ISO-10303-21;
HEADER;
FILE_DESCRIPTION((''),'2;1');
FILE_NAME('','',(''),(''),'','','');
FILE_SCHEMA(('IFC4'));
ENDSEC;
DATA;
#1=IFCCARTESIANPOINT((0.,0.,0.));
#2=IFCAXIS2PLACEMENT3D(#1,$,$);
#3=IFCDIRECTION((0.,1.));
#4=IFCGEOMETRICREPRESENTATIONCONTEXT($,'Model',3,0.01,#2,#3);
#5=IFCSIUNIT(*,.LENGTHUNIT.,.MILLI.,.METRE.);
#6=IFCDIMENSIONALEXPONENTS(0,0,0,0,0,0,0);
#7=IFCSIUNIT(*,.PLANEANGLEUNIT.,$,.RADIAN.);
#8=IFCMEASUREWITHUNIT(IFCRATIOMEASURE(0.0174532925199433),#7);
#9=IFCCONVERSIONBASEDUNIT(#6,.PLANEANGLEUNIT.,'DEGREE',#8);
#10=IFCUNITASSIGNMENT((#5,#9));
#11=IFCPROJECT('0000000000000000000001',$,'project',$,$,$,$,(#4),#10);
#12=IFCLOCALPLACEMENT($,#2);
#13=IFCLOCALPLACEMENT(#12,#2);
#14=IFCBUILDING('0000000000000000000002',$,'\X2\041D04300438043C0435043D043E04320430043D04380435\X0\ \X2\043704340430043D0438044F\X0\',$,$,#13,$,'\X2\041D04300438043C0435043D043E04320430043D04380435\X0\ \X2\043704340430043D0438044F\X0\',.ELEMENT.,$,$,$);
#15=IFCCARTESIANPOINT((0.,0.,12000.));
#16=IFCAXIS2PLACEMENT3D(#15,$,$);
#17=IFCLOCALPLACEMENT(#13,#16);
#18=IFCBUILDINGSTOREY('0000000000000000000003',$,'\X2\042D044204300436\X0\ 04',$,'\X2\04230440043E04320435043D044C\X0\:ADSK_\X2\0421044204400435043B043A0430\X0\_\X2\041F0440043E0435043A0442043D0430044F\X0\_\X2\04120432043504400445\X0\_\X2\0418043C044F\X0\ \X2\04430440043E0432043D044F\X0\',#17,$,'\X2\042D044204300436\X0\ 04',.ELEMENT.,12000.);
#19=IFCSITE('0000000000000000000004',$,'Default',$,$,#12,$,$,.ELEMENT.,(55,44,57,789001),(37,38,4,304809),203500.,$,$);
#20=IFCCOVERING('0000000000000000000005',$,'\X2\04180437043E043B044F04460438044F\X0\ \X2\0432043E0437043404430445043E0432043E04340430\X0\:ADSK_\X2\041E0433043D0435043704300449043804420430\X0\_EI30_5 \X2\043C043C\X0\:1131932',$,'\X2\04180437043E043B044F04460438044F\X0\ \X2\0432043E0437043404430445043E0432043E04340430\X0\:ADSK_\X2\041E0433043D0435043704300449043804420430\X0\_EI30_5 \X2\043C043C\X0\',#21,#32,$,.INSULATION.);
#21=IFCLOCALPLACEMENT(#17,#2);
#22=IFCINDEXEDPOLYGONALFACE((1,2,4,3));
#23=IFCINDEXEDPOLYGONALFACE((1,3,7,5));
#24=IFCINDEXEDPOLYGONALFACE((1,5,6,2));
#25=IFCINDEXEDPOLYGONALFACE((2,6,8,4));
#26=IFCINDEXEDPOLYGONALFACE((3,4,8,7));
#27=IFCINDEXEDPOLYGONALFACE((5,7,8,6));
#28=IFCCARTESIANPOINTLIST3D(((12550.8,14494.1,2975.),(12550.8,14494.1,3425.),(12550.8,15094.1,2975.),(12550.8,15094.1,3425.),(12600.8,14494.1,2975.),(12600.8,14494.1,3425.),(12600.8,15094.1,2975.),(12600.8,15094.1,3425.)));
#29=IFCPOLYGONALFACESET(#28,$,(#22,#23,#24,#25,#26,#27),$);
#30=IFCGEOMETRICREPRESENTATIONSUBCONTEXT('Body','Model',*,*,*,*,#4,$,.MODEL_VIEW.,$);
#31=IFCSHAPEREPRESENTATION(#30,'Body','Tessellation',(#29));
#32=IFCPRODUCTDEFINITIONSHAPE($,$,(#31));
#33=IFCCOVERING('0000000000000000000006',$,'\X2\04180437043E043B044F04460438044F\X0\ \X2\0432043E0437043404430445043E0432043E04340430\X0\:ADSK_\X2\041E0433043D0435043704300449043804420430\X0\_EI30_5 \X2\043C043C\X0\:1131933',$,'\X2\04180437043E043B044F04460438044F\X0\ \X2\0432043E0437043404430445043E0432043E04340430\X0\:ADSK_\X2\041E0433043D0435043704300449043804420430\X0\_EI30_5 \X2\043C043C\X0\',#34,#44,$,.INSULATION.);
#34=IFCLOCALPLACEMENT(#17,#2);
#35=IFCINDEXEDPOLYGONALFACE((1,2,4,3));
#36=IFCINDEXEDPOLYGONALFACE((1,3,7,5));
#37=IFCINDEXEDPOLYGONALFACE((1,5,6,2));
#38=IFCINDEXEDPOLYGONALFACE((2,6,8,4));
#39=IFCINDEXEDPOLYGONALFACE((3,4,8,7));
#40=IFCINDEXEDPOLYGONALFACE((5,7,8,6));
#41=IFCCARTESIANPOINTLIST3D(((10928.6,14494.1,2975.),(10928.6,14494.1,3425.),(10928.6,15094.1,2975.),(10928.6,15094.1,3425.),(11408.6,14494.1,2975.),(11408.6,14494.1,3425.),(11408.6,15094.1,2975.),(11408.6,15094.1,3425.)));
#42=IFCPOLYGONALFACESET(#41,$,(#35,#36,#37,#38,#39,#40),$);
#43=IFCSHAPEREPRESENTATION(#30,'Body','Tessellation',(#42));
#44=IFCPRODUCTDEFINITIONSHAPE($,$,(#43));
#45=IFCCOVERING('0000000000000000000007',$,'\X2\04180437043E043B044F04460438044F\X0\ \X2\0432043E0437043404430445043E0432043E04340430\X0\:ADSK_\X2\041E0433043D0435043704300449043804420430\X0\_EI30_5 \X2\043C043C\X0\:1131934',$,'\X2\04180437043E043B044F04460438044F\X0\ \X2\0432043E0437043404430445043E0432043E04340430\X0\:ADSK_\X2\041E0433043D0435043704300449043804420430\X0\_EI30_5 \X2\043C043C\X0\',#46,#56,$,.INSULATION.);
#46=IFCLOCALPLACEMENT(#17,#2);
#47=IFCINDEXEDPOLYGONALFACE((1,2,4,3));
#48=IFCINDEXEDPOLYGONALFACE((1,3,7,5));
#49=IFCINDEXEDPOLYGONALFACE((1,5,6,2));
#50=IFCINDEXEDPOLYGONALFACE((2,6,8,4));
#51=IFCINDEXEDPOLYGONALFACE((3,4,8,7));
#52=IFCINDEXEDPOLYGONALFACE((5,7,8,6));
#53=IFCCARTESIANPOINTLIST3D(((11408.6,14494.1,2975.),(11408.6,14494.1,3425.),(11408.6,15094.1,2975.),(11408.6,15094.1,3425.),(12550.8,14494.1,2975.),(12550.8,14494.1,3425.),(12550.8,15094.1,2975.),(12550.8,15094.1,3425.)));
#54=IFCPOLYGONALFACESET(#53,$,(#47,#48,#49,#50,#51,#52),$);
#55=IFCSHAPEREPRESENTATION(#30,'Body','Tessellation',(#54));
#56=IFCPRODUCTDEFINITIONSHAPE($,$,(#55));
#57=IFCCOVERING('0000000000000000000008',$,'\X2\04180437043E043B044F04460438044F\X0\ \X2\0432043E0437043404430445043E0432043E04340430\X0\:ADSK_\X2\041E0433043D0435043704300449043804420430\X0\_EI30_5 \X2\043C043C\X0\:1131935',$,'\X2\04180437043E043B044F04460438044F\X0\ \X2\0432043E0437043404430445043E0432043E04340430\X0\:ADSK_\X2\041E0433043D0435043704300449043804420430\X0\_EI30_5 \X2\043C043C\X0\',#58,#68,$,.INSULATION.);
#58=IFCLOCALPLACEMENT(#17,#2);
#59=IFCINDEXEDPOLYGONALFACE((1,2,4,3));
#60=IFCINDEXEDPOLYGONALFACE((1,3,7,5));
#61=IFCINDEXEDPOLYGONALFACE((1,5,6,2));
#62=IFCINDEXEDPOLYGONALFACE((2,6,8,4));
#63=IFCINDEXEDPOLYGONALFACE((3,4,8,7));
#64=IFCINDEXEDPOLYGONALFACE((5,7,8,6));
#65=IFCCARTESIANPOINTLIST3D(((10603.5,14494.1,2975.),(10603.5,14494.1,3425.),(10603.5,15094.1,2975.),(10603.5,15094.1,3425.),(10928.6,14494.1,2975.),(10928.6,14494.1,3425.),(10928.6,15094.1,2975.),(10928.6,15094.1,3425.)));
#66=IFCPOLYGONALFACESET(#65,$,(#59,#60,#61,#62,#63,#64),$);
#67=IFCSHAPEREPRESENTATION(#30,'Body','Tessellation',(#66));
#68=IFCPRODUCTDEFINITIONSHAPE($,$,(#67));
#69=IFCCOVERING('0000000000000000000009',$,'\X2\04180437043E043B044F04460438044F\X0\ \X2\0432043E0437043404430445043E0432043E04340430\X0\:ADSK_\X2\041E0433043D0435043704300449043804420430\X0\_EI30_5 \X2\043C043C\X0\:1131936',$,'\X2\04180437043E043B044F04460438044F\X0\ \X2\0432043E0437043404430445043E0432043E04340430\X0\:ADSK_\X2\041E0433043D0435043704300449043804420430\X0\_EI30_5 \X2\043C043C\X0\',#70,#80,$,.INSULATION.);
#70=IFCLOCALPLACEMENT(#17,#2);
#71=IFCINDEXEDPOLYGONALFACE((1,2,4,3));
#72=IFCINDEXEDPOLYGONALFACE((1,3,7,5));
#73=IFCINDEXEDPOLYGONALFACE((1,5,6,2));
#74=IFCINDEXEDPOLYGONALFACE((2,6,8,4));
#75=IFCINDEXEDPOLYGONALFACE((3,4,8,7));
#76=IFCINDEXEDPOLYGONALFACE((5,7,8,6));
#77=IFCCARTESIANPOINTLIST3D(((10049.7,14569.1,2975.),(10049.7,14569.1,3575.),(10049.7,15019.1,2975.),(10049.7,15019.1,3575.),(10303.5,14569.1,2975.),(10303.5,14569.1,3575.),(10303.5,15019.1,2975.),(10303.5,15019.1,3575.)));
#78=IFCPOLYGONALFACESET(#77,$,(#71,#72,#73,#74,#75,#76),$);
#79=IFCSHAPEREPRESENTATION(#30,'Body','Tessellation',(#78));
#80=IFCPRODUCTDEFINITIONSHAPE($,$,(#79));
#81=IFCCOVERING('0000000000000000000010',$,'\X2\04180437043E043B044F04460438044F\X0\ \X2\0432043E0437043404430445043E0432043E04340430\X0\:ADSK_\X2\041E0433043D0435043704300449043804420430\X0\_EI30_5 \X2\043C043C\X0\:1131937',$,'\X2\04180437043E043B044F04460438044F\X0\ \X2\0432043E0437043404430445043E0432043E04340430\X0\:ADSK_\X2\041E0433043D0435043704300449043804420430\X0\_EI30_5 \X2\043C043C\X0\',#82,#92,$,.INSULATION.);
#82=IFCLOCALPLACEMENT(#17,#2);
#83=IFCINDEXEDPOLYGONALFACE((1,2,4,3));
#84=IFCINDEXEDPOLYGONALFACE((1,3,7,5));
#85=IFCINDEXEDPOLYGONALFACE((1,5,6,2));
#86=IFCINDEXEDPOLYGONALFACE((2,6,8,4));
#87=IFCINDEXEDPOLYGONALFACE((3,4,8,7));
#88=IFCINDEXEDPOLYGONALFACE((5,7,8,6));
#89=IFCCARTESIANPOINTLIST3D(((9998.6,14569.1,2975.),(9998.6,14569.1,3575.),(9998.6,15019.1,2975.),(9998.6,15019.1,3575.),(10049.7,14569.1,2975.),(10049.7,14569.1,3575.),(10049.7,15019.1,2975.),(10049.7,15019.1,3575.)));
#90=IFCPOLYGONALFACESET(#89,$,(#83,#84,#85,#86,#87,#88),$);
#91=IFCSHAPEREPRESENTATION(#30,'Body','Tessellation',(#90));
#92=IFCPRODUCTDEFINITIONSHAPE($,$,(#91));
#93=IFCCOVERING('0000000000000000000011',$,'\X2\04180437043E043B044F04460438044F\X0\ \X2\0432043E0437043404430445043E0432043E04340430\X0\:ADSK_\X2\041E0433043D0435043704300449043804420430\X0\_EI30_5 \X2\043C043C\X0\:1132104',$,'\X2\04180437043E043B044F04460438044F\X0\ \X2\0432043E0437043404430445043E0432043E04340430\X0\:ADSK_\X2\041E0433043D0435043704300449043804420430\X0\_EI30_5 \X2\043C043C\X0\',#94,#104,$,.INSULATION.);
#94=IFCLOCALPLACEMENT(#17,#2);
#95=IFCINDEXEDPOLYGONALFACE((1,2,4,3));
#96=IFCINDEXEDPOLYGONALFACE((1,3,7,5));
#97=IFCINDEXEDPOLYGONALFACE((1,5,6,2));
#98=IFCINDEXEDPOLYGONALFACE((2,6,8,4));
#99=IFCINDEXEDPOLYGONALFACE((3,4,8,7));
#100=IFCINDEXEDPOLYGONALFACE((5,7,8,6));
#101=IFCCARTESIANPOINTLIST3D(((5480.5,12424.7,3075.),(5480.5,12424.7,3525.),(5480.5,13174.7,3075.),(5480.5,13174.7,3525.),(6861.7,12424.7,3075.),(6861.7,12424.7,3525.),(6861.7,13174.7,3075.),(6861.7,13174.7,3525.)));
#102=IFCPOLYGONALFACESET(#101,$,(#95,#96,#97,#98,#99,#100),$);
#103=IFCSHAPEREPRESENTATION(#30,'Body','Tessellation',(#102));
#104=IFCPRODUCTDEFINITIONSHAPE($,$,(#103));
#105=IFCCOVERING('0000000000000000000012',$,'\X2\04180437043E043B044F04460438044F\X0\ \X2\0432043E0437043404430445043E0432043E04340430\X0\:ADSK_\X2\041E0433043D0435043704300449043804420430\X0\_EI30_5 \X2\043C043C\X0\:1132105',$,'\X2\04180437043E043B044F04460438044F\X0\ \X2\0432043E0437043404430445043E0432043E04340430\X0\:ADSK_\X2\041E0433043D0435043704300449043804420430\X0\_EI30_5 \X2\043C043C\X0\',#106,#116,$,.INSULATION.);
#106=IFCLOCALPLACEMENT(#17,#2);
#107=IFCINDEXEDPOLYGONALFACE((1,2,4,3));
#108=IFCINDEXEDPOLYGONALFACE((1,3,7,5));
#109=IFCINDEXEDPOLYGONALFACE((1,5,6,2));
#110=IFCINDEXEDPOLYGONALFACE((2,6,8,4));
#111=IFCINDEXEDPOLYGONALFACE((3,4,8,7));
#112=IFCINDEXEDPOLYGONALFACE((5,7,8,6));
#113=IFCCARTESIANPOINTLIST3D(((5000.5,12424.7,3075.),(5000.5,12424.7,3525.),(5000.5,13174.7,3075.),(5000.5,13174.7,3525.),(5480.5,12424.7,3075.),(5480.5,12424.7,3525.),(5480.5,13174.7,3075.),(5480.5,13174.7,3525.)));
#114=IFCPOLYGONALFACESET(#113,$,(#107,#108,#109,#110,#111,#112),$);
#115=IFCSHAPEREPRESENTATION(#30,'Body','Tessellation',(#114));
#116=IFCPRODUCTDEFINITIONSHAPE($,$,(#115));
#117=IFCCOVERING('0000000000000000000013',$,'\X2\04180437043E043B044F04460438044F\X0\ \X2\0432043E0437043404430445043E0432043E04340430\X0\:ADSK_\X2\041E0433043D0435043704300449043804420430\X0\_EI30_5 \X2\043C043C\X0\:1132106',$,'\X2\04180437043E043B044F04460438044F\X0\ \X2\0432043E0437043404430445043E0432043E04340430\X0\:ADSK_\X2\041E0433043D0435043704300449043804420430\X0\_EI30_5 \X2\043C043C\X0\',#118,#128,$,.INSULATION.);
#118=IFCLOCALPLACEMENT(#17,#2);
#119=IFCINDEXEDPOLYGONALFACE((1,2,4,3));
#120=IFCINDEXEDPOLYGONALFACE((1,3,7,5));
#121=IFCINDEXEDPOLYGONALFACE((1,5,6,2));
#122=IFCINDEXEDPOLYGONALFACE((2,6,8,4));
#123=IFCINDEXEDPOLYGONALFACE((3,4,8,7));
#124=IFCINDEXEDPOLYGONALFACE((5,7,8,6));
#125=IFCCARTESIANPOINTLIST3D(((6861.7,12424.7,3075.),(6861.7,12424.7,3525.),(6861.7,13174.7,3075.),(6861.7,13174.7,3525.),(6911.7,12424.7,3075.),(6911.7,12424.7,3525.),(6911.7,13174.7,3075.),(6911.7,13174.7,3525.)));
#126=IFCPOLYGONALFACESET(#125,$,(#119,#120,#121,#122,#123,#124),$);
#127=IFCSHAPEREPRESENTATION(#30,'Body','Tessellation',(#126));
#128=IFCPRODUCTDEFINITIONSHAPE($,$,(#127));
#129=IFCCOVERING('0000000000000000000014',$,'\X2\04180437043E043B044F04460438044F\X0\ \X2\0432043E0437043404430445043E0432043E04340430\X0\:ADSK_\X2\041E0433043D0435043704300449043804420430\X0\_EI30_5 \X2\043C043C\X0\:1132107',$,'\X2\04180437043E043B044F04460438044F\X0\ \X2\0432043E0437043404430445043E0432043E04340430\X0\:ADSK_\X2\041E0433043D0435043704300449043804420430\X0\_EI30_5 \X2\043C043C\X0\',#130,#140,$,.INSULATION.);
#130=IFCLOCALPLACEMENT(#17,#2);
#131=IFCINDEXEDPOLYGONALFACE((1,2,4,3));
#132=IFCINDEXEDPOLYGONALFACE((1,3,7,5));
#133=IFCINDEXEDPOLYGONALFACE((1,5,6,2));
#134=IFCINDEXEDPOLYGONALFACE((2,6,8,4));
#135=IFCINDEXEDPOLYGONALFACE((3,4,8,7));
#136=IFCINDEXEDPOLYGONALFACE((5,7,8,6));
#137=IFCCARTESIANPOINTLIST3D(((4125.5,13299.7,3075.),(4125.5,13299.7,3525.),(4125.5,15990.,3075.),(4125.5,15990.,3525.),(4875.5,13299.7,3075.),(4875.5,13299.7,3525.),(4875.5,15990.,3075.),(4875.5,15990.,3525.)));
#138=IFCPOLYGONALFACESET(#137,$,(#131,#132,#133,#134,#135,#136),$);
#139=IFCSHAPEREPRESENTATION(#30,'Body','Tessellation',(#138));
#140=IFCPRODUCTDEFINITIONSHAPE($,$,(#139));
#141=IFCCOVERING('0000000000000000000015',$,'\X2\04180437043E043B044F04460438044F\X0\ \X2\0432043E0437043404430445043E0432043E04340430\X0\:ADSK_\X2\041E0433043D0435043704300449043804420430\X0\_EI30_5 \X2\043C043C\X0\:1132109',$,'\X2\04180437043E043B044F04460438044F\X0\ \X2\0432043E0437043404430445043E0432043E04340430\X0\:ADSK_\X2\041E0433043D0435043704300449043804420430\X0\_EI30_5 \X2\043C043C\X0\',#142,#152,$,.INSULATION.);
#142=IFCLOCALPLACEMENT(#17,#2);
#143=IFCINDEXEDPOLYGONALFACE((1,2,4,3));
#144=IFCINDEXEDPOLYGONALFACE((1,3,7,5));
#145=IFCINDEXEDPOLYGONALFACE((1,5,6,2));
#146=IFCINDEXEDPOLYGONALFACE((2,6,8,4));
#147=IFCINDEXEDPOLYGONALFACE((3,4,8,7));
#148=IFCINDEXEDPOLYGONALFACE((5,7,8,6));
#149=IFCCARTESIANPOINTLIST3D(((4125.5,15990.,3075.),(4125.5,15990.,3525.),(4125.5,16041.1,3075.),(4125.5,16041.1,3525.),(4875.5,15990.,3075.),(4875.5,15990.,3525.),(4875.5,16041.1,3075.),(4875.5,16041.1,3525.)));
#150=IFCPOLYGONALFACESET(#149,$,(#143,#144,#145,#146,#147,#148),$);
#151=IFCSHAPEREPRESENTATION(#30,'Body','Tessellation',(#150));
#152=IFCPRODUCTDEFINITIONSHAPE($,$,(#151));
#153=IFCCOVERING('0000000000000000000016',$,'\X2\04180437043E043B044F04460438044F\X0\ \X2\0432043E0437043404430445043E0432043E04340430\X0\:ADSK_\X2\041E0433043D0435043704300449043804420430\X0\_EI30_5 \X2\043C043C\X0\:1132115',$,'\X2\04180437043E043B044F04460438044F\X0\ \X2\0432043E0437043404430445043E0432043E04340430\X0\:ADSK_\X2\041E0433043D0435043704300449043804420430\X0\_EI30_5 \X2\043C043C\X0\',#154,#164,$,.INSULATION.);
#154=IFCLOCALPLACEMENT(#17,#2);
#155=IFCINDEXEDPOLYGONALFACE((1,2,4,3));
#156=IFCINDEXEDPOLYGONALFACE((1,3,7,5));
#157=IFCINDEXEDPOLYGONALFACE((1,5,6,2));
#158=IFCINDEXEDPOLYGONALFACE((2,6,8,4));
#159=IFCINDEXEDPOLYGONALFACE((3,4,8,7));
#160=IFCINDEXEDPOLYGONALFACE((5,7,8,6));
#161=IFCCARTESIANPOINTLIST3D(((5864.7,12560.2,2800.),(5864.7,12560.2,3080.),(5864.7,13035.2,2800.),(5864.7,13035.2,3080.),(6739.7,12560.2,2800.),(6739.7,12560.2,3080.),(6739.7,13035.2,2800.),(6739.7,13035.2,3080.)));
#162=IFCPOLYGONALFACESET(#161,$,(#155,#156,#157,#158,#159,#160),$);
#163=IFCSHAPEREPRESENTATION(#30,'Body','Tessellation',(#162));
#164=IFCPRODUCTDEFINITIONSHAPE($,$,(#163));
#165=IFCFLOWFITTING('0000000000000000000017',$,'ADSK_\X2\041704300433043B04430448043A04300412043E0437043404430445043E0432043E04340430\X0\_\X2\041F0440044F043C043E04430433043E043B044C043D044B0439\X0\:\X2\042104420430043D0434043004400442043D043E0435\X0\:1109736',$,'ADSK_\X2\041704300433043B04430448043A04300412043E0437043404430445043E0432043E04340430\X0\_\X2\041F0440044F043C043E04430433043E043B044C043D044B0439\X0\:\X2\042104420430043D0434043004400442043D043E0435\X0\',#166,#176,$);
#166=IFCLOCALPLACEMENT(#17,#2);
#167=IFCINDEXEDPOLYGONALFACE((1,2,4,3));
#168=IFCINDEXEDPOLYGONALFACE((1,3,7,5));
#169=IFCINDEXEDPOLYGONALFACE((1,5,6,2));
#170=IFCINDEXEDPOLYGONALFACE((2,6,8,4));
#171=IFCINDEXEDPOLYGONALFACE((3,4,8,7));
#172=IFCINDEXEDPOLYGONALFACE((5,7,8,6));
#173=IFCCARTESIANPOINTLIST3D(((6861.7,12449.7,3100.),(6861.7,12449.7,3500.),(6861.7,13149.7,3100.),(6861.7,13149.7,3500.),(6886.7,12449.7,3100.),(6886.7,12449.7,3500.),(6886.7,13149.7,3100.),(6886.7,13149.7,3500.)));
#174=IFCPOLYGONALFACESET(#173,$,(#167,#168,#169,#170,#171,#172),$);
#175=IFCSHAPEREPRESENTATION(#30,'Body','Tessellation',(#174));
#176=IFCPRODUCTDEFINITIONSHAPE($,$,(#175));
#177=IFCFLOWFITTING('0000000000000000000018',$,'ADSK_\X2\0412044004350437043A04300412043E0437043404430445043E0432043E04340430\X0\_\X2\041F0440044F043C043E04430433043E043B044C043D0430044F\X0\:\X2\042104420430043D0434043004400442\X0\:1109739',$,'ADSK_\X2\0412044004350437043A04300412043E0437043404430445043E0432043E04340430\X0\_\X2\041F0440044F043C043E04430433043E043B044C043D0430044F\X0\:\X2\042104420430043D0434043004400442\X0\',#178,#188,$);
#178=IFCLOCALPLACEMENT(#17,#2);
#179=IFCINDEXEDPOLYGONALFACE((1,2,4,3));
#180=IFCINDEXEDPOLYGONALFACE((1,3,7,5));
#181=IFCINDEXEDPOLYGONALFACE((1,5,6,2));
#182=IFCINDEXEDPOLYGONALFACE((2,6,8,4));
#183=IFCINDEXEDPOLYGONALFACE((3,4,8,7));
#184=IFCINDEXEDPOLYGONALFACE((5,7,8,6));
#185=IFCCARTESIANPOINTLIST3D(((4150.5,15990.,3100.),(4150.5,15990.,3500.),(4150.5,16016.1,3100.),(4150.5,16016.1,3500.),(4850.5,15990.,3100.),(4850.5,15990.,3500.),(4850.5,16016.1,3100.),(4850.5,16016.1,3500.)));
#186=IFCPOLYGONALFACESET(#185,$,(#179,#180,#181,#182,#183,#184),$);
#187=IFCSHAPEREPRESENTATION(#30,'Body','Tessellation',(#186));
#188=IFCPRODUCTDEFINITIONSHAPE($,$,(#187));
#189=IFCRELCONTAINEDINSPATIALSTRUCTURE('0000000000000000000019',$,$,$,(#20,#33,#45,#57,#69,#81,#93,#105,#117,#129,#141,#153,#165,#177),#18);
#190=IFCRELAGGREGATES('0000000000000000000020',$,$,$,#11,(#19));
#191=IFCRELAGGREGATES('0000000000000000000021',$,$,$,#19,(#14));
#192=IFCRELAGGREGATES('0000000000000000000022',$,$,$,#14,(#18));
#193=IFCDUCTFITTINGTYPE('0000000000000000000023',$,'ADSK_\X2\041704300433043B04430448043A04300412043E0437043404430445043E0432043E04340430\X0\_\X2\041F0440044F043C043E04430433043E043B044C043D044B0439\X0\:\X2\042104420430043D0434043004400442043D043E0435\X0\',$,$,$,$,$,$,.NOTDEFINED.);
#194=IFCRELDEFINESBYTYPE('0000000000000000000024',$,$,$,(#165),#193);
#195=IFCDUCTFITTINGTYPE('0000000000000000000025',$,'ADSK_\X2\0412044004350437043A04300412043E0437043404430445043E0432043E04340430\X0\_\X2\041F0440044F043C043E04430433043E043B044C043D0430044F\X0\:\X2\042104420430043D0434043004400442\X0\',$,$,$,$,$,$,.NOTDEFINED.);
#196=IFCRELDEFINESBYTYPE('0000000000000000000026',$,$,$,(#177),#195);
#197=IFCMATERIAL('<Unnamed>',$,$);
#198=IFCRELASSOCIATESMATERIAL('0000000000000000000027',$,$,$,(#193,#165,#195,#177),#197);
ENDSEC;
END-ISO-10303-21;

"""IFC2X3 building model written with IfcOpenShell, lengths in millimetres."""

from ifc_helpers import new_model, entity, si_unit, converted_unit, direction, frame, frame_2d, origin, origin_2d_with_axis, place, context, subcontext, project, spatial, rectangle, extrude, source, transform, mapped, material, type_object, type_shapes, element, save


model = new_model("IFC2X3")

# Units and contexts
model_context = context("Model", 3, precision=0.01, world=origin(), true_north=direction((0.0, 1.0)))
body_context = subcontext(model_context, "Body", "Model", "MODEL_VIEW")
ifc_project = project(units=[si_unit("LENGTHUNIT", "METRE", prefix="MILLI"), converted_unit("PLANEANGLEUNIT", "DEGREE", entity("IfcRatioMeasure", 0.0174532925199433), si_unit("PLANEANGLEUNIT", "RADIAN"), dimensions=[0, 0, 0, 0, 0, 0, 0])], contexts=[model_context])

# Site, building, storey
site_placement = place(None, frame((0.0, 0.0, 0.0)))
site = spatial("IfcSite", under=ifc_project, at=site_placement, Name="Default", CompositionType="ELEMENT", RefLatitude=(55, 44, 57, 789001), RefLongitude=(37, 38, 4, 304809), RefElevation=203500.0)
building_placement = place(site_placement, origin())
building = spatial("IfcBuilding", under=site, at=building_placement, Name="Наименование здания", LongName="Наименование здания", CompositionType="ELEMENT")
storey_placement = place(building_placement, frame((0.0, 0.0, 12000.0)))
storey = spatial("IfcBuildingStorey", under=building, at=storey_placement, Name="Этаж 04", ObjectType="Уровень:ADSK_Стрелка_Проектная_Вверх_Имя уровня", LongName="Этаж 04", CompositionType="ELEMENT", Elevation=12000.0)

# Coverings
covering_1_placement = place(storey_placement, frame((12550.8, 14494.1, 2975.0)))
element("IfcCovering", 1, at=covering_1_placement, inside=storey, Name="Изоляция воздуховода:ADSK_Огнезащита_EI30_5 мм:1131932", ObjectType="Изоляция воздуховода:ADSK_Огнезащита_EI30_5 мм", PredefinedType="INSULATION", context=body_context, shape_type="SweptSolid", body=[
    extrude(rectangle(XDim=50.0, YDim=600.0, at=frame_2d((0.0, 0.0), x_axis=(1.0, 0.0))), frame((25.0, 300.0, 0.0), z_axis=(0.0, 0.0, 1.0), x_axis=(-1.0, 0.0, 0.0)), (0.0, 0.0, 1.0), 450.0),
])
covering_2_placement = place(storey_placement, frame((10928.6, 14494.1, 2975.0)))
element("IfcCovering", 2, at=covering_2_placement, inside=storey, Name="Изоляция воздуховода:ADSK_Огнезащита_EI30_5 мм:1131933", ObjectType="Изоляция воздуховода:ADSK_Огнезащита_EI30_5 мм", PredefinedType="INSULATION", context=body_context, shape_type="SweptSolid", body=[
    extrude(rectangle(XDim=480.0, YDim=600.0, at=frame_2d((0.0, 0.0), x_axis=(1.0, 0.0))), frame((240.0, 300.0, 0.0), z_axis=(0.0, 0.0, 1.0), x_axis=(-1.0, 0.0, 0.0)), (0.0, 0.0, 1.0), 450.0),
])
covering_3_placement = place(storey_placement, frame((11408.6, 14494.1, 2975.0)))
element("IfcCovering", 3, at=covering_3_placement, inside=storey, Name="Изоляция воздуховода:ADSK_Огнезащита_EI30_5 мм:1131934", ObjectType="Изоляция воздуховода:ADSK_Огнезащита_EI30_5 мм", PredefinedType="INSULATION", context=body_context, shape_type="SweptSolid", body=[
    extrude(rectangle(XDim=1142.1, YDim=600.0, at=origin_2d_with_axis()), frame((571.1, 300.0, 0.0), z_axis=(0.0, 0.0, 1.0), x_axis=(-1.0, 0.0, 0.0)), (0.0, 0.0, 1.0), 450.0),
])
covering_4_placement = place(storey_placement, frame((10603.5, 14494.1, 2975.0)))
element("IfcCovering", 4, at=covering_4_placement, inside=storey, Name="Изоляция воздуховода:ADSK_Огнезащита_EI30_5 мм:1131935", ObjectType="Изоляция воздуховода:ADSK_Огнезащита_EI30_5 мм", PredefinedType="INSULATION", context=body_context, shape_type="SweptSolid", body=[
    extrude(rectangle(XDim=325.1, YDim=600.0, at=origin_2d_with_axis()), frame((162.6, 300.0, 0.0), z_axis=(0.0, 0.0, 1.0), x_axis=(-1.0, 0.0, 0.0)), (0.0, 0.0, 1.0), 450.0),
])
covering_5_placement = place(storey_placement, frame((10049.7, 14569.1, 2975.0)))
element("IfcCovering", 5, at=covering_5_placement, inside=storey, Name="Изоляция воздуховода:ADSK_Огнезащита_EI30_5 мм:1131936", ObjectType="Изоляция воздуховода:ADSK_Огнезащита_EI30_5 мм", PredefinedType="INSULATION", context=body_context, shape_type="SweptSolid", body=[
    extrude(rectangle(XDim=253.8, YDim=450.0, at=frame_2d((0.0, 0.0), x_axis=(1.0, 0.0))), frame((126.9, 225.0, 0.0), z_axis=(0.0, 0.0, 1.0), x_axis=(-1.0, 0.0, 0.0)), (0.0, 0.0, 1.0), 600.0),
])
covering_6_placement = place(storey_placement, frame((9998.6, 14569.1, 2975.0)))
element("IfcCovering", 6, at=covering_6_placement, inside=storey, Name="Изоляция воздуховода:ADSK_Огнезащита_EI30_5 мм:1131937", ObjectType="Изоляция воздуховода:ADSK_Огнезащита_EI30_5 мм", PredefinedType="INSULATION", context=body_context, shape_type="SweptSolid", body=[
    extrude(rectangle(XDim=450.0, YDim=51.1, at=frame_2d((0.0, 0.0), x_axis=(1.0, 0.0))), frame((25.5, 225.0, 0.0), z_axis=(0.0, 0.0, 1.0), x_axis=(0.0, 1.0, 0.0)), (0.0, 0.0, 1.0), 600.0),
])
covering_7_placement = place(storey_placement, frame((5480.5, 12424.7, 3075.0)))
element("IfcCovering", 7, at=covering_7_placement, inside=storey, Name="Изоляция воздуховода:ADSK_Огнезащита_EI30_5 мм:1132104", ObjectType="Изоляция воздуховода:ADSK_Огнезащита_EI30_5 мм", PredefinedType="INSULATION", context=body_context, shape_type="SweptSolid", body=[
    extrude(rectangle(XDim=1381.3, YDim=750.0, at=origin_2d_with_axis()), frame((690.6, 375.0, 0.0)), (0.0, 0.0, 1.0), 450.0),
])
covering_8_placement = place(storey_placement, frame((5000.5, 12424.7, 3075.0)))
element("IfcCovering", 8, at=covering_8_placement, inside=storey, Name="Изоляция воздуховода:ADSK_Огнезащита_EI30_5 мм:1132105", ObjectType="Изоляция воздуховода:ADSK_Огнезащита_EI30_5 мм", PredefinedType="INSULATION", context=body_context, shape_type="SweptSolid", body=[
    extrude(rectangle(XDim=480.0, YDim=750.0, at=frame_2d((0.0, 0.0), x_axis=(1.0, 0.0))), frame((240.0, 375.0, 0.0)), (0.0, 0.0, 1.0), 450.0),
])
covering_9_placement = place(storey_placement, frame((6861.7, 12424.7, 3075.0)))
element("IfcCovering", 9, at=covering_9_placement, inside=storey, Name="Изоляция воздуховода:ADSK_Огнезащита_EI30_5 мм:1132106", ObjectType="Изоляция воздуховода:ADSK_Огнезащита_EI30_5 мм", PredefinedType="INSULATION", context=body_context, shape_type="SweptSolid", body=[
    extrude(rectangle(XDim=50.0, YDim=750.0, at=frame_2d((0.0, 0.0), x_axis=(1.0, 0.0))), frame((25.0, 375.0, 0.0), z_axis=(0.0, 0.0, 1.0), x_axis=(-1.0, 0.0, 0.0)), (0.0, 0.0, 1.0), 450.0),
])
covering_10_placement = place(storey_placement, frame((4125.5, 13299.7, 3075.0)))
element("IfcCovering", 10, at=covering_10_placement, inside=storey, Name="Изоляция воздуховода:ADSK_Огнезащита_EI30_5 мм:1132107", ObjectType="Изоляция воздуховода:ADSK_Огнезащита_EI30_5 мм", PredefinedType="INSULATION", context=body_context, shape_type="SweptSolid", body=[
    extrude(rectangle(XDim=2690.3, YDim=750.0, at=frame_2d((0.0, 0.0), x_axis=(1.0, 0.0))), frame((375.0, 1345.2, 0.0), z_axis=(0.0, 0.0, 1.0), x_axis=(0.0, 1.0, 0.0)), (0.0, 0.0, 1.0), 450.0),
])
covering_11_placement = place(storey_placement, frame((4125.5, 15990.0, 3075.0)))
element("IfcCovering", 11, at=covering_11_placement, inside=storey, Name="Изоляция воздуховода:ADSK_Огнезащита_EI30_5 мм:1132109", ObjectType="Изоляция воздуховода:ADSK_Огнезащита_EI30_5 мм", PredefinedType="INSULATION", context=body_context, shape_type="SweptSolid", body=[
    extrude(rectangle(XDim=750.0, YDim=51.1, at=frame_2d((0.0, 0.0), x_axis=(1.0, 0.0))), frame((375.0, 25.5, 0.0)), (0.0, 0.0, 1.0), 450.0),
])
covering_12_placement = place(storey_placement, frame((5864.7, 12560.2, 2800.0)))
element("IfcCovering", 12, at=covering_12_placement, inside=storey, Name="Изоляция воздуховода:ADSK_Огнезащита_EI30_5 мм:1132115", ObjectType="Изоляция воздуховода:ADSK_Огнезащита_EI30_5 мм", PredefinedType="INSULATION", context=body_context, shape_type="SweptSolid", body=[
    extrude(rectangle(XDim=875.0, YDim=475.0, at=origin_2d_with_axis()), frame((437.5, 237.5, 0.0), z_axis=(0.0, 0.0, 1.0), x_axis=(-1.0, 0.0, 0.0)), (0.0, 0.0, 1.0), 280.0),
])

# Flow fittings
ifc_material_1 = material(Name="<Unnamed>")
duct_fitting_type_1 = type_object("IfcDuctFittingType", Name="ADSK_ЗаглушкаВоздуховода_Прямоугольный:Стандартное", PredefinedType="NOTDEFINED", material=ifc_material_1)
shared_shape_1 = source(origin(), body_context, "Body", "SweptSolid", [
    extrude(rectangle(XDim=25.0, YDim=700.0, at=frame_2d((0.0, 0.0), x_axis=(1.0, 0.0))), frame((12.5, 0.0, -200.0)), (0.0, 0.0, 1.0), 400.0),
])
type_shapes(duct_fitting_type_1, [shared_shape_1])
flow_fitting_1_placement = place(storey_placement, frame((6861.7, 12799.7, 3300.0)))
element("IfcFlowFitting", 13, at=flow_fitting_1_placement, inside=storey, type_object=duct_fitting_type_1, material=ifc_material_1, Name="ADSK_ЗаглушкаВоздуховода_Прямоугольный:Стандартное:1109736", ObjectType="ADSK_ЗаглушкаВоздуховода_Прямоугольный:Стандартное", context=body_context, shape_type="MappedRepresentation", body=[
    mapped(shared_shape_1, transform((0.0, 0.0, 0.0), scale=1.0)),
])
duct_fitting_type_2 = type_object("IfcDuctFittingType", Name="ADSK_ВрезкаВоздуховода_Прямоугольная:Стандарт", PredefinedType="NOTDEFINED", material=ifc_material_1)
shared_shape_2 = source(origin(), body_context, "Body", "SweptSolid", [
    extrude(rectangle(XDim=26.1, YDim=400.0, at=frame_2d((0.0, 0.0), x_axis=(1.0, 0.0))), frame((7.0, 0.0, -350.0)), (0.0, 0.0, 1.0), 700.0),
])
type_shapes(duct_fitting_type_2, [shared_shape_2])
flow_fitting_2_placement = place(storey_placement, frame((4500.5, 16010.0, 3300.0), z_axis=(-1.0, 0.0, 0.0), x_axis=(0.0, -1.0, 0.0)))
element("IfcFlowFitting", 14, at=flow_fitting_2_placement, inside=storey, type_object=duct_fitting_type_2, material=ifc_material_1, Name="ADSK_ВрезкаВоздуховода_Прямоугольная:Стандарт:1109739", ObjectType="ADSK_ВрезкаВоздуховода_Прямоугольная:Стандарт", context=body_context, shape_type="MappedRepresentation", body=[
    mapped(shared_shape_2, transform((0.0, 0.0, 0.0), scale=1.0)),
])

save(model, "model.ifc")
